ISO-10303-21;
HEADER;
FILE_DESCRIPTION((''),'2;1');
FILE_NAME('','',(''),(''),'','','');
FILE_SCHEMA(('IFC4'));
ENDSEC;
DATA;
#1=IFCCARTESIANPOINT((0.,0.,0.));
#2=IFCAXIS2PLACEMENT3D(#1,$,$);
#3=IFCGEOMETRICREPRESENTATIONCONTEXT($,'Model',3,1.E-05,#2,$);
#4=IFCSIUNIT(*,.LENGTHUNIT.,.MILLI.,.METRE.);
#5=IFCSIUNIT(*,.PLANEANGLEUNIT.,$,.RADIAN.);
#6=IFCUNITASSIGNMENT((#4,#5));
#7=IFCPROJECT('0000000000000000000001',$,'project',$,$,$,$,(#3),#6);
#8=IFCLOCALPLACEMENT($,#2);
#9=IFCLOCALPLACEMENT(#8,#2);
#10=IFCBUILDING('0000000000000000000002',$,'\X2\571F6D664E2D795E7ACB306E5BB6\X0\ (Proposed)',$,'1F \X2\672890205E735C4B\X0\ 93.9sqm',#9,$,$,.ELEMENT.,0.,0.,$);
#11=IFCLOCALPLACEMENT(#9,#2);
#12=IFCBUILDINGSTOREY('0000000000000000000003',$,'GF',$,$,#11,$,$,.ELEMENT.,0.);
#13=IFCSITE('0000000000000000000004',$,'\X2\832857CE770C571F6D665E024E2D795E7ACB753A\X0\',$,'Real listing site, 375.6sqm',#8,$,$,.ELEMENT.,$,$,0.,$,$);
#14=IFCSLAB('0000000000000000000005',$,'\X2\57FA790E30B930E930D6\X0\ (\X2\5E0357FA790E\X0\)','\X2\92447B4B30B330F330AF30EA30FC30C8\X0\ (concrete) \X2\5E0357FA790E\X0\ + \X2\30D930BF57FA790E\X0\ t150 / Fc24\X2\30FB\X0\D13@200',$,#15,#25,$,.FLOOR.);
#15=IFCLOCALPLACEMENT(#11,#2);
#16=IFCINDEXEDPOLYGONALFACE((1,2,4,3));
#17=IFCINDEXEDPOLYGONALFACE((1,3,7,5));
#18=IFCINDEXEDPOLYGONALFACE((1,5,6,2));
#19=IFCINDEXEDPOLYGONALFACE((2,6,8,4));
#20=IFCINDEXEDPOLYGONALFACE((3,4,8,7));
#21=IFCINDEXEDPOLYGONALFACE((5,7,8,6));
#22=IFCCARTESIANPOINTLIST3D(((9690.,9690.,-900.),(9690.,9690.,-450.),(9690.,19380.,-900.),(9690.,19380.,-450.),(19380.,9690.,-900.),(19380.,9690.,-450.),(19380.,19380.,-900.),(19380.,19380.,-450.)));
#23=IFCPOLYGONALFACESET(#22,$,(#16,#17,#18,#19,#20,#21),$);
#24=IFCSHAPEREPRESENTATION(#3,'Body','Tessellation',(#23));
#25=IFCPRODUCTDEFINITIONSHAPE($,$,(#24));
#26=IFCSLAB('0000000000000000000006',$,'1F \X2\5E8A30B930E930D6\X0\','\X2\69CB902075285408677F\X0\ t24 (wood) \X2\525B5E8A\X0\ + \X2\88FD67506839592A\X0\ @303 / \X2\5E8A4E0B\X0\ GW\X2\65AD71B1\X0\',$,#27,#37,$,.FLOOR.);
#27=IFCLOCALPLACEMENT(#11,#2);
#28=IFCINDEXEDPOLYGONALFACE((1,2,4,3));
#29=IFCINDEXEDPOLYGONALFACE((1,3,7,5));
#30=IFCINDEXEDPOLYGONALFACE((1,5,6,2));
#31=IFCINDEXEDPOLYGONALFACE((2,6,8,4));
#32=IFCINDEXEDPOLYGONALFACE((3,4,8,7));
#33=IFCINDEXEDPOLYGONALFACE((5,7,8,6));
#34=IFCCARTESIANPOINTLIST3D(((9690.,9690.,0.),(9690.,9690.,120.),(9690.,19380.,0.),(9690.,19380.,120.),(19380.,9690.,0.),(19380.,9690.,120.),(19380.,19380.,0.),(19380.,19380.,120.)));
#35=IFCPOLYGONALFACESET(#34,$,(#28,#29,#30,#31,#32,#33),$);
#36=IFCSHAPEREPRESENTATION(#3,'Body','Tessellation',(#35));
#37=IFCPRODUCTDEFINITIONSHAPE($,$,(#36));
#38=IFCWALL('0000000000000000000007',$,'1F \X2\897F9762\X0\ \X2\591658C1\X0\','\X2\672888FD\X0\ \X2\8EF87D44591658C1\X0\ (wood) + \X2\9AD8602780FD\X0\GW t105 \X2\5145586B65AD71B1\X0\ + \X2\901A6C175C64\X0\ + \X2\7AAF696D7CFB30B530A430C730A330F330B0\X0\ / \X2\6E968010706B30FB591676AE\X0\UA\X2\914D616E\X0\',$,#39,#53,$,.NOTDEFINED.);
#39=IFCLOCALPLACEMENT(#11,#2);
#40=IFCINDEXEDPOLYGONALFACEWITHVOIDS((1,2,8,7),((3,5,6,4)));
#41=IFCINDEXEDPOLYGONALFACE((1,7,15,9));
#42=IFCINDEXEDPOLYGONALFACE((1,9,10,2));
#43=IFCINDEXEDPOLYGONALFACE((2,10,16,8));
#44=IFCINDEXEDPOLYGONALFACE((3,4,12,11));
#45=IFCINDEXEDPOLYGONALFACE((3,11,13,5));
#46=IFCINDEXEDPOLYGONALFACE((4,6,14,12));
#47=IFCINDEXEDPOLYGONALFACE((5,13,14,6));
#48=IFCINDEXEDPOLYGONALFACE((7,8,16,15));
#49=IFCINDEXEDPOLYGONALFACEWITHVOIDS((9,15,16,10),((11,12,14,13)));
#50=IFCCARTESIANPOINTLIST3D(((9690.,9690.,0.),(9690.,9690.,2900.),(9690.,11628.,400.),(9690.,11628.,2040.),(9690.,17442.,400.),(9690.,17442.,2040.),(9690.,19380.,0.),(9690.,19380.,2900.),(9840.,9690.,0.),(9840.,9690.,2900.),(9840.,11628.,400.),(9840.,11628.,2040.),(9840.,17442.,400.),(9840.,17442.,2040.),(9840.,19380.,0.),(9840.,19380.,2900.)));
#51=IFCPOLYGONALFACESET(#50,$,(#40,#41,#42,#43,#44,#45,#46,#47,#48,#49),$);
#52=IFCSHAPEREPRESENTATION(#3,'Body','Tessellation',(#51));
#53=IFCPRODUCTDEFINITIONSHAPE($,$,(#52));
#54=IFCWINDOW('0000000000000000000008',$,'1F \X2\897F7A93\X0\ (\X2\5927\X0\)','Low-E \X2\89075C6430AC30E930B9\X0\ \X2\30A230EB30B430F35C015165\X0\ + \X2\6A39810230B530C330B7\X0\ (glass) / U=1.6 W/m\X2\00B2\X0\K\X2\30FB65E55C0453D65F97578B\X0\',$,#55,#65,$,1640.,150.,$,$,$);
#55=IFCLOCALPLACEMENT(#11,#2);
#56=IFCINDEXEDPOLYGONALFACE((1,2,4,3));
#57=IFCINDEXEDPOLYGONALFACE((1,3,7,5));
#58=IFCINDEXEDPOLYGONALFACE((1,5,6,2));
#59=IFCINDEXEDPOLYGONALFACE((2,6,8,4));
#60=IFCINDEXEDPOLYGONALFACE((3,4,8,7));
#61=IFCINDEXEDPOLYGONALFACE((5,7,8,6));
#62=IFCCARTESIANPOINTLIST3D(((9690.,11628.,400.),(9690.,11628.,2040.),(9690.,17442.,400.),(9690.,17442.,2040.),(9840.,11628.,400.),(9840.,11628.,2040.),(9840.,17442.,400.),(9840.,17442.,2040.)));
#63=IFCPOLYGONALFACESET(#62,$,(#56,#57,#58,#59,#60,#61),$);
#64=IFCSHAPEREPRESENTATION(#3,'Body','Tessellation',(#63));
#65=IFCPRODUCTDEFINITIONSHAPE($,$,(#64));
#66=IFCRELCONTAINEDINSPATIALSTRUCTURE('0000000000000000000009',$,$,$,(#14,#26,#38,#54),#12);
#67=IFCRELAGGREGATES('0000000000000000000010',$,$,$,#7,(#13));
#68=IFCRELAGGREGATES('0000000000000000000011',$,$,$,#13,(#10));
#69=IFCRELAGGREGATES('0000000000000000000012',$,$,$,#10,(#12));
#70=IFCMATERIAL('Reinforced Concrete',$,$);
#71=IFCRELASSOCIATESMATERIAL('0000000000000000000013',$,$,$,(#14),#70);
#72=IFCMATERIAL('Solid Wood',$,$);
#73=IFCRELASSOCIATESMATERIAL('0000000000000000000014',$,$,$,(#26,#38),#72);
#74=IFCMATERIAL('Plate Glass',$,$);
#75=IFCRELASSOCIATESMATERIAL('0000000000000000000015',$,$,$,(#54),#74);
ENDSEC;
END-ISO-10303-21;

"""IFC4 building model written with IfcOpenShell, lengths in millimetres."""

from ifc_helpers import new_model, si_unit, frame, frame_2d, origin, place, context, project, spatial, rectangle, extrude, material, element, fill, save


model = new_model("IFC4")

# Units and contexts
model_context = context("Model", 3, precision=1e-05, world=origin())
ifc_project = project(units=[si_unit("LENGTHUNIT", "METRE", prefix="MILLI"), si_unit("PLANEANGLEUNIT", "RADIAN")], contexts=[model_context])

# Site, building, storey
site_placement = place(None, origin())
site = spatial("IfcSite", under=ifc_project, at=site_placement, Name="茨城県土浦市中神立町", ObjectType="Real listing site, 375.6sqm", CompositionType="ELEMENT", RefElevation=0.0)
building_placement = place(site_placement, origin())
building = spatial("IfcBuilding", under=site, at=building_placement, Name="土浦中神立の家 (Proposed)", ObjectType="1F 木造平屋 93.9sqm", CompositionType="ELEMENT", ElevationOfRefHeight=0.0, ElevationOfTerrain=0.0)
storey_placement = place(building_placement, origin())
storey = spatial("IfcBuildingStorey", under=building, at=storey_placement, Name="GF", CompositionType="ELEMENT", Elevation=0.0)

# Slabs
ifc_material_1 = material(Name="Reinforced Concrete")
slab_1_placement = place(storey_placement, frame((4845.0, 4845.0, -450.0)))
element("IfcSlab", 1, at=slab_1_placement, inside=storey, material=ifc_material_1, Name="基礎スラブ (布基礎)", Description="鉄筋コンクリート (concrete) 布基礎 + ベタ基礎 t150 / Fc24・D13@200", PredefinedType="FLOOR", context=model_context, shape_type="SweptSolid", body=[
    extrude(rectangle(XDim=9690.0, YDim=9690.0, at=frame_2d((4845.0, 4845.0))), frame((4845.0, 4845.0, -450.0)), (0.0, 0.0, 1.0), 450.0),
])
ifc_material_2 = material(Name="Solid Wood")
slab_2_placement = place(storey_placement, frame((4845.0, 4845.0, 0.0)))
element("IfcSlab", 2, at=slab_2_placement, inside=storey, material=ifc_material_2, Name="1F 床スラブ", Description="構造用合板 t24 (wood) 剛床 + 製材根太 @303 / 床下 GW断熱", PredefinedType="FLOOR", context=model_context, shape_type="SweptSolid", body=[
    extrude(rectangle(XDim=9690.0, YDim=9690.0, at=frame_2d((4845.0, 4845.0))), frame((4845.0, 4845.0, 0.0)), (0.0, 0.0, 1.0), 120.0),
])

# Shared definitions
ifc_material_3 = material(Name="Plate Glass")

# Wall, opening, window
wall_1_placement = place(storey_placement, frame((4845.0, 4845.0, 0.0)))
wall_1 = element("IfcWall", 3, at=wall_1_placement, inside=storey, material=ifc_material_2, Name="1F 西面 外壁", Description="木製 軸組外壁 (wood) + 高性能GW t105 充填断熱 + 通気層 + 窯業系サイディング / 準耐火・外皮UA配慮", PredefinedType="NOTDEFINED", context=model_context, shape_type="SweptSolid", body=[
    extrude(rectangle(XDim=150.0, YDim=9690.0, at=frame_2d((75.0, 4845.0))), frame((4845.0, 4845.0, 0.0)), (0.0, 0.0, 1.0), 2900.0),
])
opening_1_placement = place(storey_placement, frame((4845.0, 5814.0, 200.0)))
opening_1 = element("IfcOpeningElement", 4, at=opening_1_placement, cuts=wall_1, PredefinedType="NOTDEFINED", context=model_context, shape_type="SweptSolid", body=[
    extrude(rectangle(XDim=150.0, YDim=5814.0, at=frame_2d((75.0, 2907.0))), frame((4845.0, 5814.0, 200.0)), (0.0, 0.0, 1.0), 1640.0),
])
window_1_placement = place(storey_placement, frame((4845.0, 5814.0, 200.0)))
window_1 = element("IfcWindow", 5, at=window_1_placement, inside=storey, material=ifc_material_3, Name="1F 西窓 (大)", Description="Low-E 複層ガラス アルゴン封入 + 樹脂サッシ (glass) / U=1.6 W/m²K・日射取得型", OverallHeight=1640.0, OverallWidth=150.0, context=model_context, shape_type="SweptSolid", body=[
    extrude(rectangle(XDim=150.0, YDim=5814.0, at=frame_2d((75.0, 2907.0))), frame((4845.0, 5814.0, 200.0)), (0.0, 0.0, 1.0), 1640.0),
])
fill(opening_1, window_1)

save(model, "model.ifc")
